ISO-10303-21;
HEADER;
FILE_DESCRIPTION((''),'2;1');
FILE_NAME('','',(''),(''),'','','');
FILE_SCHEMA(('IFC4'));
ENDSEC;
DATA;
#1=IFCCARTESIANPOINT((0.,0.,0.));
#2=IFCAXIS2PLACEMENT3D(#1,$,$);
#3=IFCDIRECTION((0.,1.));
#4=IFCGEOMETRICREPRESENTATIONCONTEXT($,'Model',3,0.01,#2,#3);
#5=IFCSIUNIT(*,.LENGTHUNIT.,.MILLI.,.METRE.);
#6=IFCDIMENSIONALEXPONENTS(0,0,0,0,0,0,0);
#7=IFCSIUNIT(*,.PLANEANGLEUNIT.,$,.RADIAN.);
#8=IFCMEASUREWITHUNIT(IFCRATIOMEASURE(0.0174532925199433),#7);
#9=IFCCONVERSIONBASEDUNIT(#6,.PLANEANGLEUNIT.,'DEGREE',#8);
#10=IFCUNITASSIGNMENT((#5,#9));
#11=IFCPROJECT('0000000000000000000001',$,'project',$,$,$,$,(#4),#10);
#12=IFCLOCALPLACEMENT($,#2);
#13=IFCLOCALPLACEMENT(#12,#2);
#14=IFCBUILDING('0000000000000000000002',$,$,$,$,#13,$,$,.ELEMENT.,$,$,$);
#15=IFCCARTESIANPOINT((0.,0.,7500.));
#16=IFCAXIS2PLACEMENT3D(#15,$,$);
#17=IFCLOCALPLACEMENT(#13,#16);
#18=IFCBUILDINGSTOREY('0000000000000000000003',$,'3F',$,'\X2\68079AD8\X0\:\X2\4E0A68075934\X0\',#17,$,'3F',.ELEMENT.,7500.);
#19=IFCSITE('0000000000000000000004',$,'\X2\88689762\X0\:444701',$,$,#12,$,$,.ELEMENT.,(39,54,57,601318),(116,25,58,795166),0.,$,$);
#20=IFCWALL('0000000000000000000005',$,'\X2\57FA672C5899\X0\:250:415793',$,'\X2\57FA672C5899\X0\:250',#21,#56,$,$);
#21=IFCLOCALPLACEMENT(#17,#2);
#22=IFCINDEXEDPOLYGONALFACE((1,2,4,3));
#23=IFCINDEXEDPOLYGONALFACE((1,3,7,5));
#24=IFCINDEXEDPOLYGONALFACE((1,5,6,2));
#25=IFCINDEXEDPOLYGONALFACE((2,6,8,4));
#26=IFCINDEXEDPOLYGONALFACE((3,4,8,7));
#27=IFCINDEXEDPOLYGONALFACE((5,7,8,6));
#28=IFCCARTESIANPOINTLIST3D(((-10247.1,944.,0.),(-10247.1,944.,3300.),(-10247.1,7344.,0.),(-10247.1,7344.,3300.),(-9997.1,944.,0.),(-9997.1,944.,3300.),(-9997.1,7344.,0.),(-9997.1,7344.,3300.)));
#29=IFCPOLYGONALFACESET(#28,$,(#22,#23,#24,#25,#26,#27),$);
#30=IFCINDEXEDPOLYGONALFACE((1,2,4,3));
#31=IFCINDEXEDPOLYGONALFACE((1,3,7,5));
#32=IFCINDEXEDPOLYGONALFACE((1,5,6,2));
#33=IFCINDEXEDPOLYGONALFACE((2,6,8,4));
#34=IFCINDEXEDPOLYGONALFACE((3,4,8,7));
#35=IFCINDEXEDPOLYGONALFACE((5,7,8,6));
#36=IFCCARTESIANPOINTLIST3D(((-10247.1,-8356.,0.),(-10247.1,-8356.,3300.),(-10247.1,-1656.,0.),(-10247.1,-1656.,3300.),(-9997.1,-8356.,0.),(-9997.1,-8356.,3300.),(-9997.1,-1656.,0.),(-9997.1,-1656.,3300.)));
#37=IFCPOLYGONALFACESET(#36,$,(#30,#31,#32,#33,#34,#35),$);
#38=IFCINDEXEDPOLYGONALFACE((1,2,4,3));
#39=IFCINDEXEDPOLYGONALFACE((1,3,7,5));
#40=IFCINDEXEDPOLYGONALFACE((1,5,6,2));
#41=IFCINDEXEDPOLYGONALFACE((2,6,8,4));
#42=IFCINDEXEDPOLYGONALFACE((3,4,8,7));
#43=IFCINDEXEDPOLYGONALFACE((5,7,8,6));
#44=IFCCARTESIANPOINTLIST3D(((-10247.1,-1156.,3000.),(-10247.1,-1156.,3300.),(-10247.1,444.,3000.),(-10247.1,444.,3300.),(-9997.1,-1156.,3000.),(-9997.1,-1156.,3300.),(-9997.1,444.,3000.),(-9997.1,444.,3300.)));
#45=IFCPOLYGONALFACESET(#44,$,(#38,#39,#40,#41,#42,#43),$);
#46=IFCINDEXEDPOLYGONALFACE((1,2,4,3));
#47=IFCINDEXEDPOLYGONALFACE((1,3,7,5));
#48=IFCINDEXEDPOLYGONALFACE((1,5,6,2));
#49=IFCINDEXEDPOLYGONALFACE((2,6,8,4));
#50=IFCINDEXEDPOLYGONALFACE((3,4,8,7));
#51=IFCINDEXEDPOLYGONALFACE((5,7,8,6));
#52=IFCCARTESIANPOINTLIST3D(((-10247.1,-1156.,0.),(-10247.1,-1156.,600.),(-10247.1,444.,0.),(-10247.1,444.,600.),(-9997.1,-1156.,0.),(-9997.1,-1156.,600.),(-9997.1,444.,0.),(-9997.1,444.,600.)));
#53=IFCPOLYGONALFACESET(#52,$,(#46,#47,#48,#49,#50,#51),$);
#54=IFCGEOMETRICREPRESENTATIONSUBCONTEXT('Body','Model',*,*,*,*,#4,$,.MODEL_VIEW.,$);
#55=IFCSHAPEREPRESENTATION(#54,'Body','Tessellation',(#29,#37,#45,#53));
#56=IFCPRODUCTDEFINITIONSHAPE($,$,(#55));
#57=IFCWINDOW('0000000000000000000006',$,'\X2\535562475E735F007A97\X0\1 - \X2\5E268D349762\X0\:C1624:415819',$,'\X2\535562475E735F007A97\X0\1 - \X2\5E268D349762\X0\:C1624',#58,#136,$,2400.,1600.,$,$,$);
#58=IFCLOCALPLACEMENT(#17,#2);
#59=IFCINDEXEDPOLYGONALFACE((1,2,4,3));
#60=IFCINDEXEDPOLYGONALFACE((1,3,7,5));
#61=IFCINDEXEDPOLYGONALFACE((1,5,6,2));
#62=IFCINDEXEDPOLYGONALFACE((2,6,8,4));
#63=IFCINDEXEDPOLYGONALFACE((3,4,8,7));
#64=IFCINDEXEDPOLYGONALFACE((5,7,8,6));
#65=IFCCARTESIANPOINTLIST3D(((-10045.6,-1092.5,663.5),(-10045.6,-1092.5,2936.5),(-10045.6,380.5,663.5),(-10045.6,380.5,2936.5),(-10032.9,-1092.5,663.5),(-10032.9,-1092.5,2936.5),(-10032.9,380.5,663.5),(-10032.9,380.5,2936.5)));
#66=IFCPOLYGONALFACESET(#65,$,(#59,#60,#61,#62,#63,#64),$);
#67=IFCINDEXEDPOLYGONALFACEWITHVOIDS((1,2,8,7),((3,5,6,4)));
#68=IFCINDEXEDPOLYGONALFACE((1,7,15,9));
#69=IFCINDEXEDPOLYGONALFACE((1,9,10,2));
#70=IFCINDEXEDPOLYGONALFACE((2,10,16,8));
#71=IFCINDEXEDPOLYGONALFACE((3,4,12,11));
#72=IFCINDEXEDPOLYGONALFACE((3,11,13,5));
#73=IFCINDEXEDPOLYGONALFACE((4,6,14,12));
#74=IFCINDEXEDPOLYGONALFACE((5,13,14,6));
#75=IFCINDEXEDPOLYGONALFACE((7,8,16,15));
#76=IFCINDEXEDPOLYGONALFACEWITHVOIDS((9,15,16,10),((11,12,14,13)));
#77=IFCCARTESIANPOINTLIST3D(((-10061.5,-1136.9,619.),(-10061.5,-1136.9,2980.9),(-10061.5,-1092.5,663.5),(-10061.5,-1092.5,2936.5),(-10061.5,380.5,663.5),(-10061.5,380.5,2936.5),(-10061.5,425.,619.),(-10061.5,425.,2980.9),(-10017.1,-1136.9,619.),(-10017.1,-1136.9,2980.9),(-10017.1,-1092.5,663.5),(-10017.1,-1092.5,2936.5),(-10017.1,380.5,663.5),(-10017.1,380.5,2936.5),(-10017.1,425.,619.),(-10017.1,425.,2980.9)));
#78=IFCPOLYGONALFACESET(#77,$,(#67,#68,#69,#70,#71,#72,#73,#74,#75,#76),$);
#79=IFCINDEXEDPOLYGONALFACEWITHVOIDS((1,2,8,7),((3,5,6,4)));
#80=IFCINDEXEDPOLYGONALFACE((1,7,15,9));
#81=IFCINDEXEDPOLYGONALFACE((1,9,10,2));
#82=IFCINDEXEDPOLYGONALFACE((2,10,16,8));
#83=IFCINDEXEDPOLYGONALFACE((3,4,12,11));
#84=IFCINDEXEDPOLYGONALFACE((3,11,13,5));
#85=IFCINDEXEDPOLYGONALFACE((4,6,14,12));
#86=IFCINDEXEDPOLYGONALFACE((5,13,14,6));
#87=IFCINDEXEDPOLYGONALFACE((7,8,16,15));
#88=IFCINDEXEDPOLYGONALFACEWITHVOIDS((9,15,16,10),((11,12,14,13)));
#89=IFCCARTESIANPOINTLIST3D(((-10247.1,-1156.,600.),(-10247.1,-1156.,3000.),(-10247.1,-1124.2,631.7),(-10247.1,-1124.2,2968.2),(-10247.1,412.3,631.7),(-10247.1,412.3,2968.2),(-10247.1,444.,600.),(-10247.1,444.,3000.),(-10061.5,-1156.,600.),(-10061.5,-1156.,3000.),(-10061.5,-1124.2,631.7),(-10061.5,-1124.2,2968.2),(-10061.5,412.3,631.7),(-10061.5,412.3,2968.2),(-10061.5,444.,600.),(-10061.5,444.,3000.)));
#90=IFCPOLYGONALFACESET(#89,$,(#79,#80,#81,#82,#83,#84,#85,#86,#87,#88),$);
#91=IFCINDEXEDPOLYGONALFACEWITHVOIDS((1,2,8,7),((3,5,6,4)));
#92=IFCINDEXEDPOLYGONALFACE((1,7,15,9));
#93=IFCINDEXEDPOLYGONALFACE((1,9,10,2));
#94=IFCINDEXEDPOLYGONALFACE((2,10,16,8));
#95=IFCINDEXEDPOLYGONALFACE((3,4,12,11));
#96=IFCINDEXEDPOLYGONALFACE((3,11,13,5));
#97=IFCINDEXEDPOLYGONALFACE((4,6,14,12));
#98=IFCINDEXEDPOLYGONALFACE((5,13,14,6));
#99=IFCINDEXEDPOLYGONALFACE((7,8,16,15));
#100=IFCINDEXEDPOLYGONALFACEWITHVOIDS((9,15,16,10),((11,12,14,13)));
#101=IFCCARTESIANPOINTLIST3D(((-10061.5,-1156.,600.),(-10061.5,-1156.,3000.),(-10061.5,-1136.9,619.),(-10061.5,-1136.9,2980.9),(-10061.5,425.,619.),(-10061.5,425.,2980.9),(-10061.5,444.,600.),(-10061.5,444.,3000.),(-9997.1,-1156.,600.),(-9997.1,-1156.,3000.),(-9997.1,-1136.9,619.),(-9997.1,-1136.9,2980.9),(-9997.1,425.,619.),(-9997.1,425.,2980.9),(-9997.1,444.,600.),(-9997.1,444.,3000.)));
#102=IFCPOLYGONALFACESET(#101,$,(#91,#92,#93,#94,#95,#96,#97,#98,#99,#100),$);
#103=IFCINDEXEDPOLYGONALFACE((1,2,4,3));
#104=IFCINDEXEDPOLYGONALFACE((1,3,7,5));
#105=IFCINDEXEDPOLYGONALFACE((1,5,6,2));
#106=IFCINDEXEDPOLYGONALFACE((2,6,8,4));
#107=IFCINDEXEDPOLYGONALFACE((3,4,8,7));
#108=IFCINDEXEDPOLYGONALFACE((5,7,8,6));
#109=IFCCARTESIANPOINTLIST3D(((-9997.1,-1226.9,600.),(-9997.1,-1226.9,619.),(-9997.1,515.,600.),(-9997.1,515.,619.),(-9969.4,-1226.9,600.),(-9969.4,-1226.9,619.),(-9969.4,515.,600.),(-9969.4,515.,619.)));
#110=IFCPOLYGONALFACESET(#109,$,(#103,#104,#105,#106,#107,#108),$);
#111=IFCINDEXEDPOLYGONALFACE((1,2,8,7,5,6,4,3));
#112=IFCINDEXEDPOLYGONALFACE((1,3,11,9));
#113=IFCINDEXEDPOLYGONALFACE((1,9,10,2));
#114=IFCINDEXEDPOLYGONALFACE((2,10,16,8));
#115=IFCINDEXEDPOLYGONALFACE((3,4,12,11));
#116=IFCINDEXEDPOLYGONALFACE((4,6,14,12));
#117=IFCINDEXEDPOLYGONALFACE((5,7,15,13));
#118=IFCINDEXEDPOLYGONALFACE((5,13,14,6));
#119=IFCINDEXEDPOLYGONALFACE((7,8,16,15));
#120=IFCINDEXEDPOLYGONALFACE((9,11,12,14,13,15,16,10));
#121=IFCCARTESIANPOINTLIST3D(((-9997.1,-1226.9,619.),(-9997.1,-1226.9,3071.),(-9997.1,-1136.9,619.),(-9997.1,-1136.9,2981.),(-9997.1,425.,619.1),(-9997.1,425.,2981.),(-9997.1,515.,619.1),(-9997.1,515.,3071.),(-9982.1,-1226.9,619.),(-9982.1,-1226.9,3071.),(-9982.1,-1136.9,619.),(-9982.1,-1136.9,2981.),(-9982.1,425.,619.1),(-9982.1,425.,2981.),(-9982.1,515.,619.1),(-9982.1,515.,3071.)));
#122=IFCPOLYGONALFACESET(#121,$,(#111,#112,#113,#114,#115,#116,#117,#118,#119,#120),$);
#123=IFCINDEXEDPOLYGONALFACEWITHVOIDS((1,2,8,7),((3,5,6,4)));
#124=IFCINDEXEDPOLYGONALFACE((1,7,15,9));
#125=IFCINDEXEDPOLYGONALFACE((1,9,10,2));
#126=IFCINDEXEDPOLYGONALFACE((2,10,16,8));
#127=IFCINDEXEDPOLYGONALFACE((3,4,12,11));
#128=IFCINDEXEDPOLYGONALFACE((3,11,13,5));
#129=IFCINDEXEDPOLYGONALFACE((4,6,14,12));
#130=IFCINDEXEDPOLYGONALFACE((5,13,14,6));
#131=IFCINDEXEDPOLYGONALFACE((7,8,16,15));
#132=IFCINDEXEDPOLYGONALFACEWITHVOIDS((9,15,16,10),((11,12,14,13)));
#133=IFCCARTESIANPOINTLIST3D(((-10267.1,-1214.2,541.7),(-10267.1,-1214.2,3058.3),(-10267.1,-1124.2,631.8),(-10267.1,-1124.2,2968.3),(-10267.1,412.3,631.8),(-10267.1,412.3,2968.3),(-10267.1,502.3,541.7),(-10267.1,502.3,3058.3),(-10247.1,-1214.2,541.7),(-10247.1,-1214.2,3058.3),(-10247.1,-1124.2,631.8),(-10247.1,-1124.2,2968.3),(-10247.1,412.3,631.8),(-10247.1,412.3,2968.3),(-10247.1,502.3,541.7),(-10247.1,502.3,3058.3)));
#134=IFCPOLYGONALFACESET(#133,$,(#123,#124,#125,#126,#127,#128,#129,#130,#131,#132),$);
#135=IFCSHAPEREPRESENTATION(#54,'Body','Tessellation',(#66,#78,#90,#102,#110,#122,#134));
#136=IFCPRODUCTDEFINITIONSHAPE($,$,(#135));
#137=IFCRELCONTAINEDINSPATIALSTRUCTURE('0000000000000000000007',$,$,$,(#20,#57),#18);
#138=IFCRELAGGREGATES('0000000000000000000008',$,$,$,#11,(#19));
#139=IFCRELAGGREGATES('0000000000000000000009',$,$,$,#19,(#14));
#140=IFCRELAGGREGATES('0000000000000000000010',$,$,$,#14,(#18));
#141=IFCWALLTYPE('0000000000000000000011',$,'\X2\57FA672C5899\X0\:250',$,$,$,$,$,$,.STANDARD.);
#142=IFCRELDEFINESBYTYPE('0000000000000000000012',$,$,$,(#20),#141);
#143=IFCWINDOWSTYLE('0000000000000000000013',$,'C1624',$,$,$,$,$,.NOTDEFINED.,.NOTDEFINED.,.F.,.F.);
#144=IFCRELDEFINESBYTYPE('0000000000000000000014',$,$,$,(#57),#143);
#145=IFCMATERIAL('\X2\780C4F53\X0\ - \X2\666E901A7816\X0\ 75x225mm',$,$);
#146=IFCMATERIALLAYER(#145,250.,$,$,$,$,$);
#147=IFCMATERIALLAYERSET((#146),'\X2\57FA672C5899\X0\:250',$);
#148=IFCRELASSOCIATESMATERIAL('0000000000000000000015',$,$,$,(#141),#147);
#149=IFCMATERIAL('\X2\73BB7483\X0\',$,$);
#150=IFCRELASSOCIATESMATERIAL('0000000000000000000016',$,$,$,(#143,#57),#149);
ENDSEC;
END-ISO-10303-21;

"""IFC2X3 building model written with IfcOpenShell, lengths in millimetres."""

from ifc_helpers import new_model, entity, si_unit, converted_unit, direction, frame, frame_2d, origin, origin_2d_with_axis, place, context, subcontext, project, spatial, polyline, rectangle, outline, extrude, source, transform, mapped, material, layer, layer_set, type_object, type_shapes, element, fill, save


model = new_model("IFC2X3")

# Units and contexts
model_context = context("Model", 3, precision=0.01, world=origin(), true_north=direction((0.0, 1.0)))
body_context = subcontext(model_context, "Body", "Model", "MODEL_VIEW")
ifc_project = project(units=[si_unit("LENGTHUNIT", "METRE", prefix="MILLI"), converted_unit("PLANEANGLEUNIT", "DEGREE", entity("IfcRatioMeasure", 0.0174532925199433), si_unit("PLANEANGLEUNIT", "RADIAN"), dimensions=[0, 0, 0, 0, 0, 0, 0])], contexts=[model_context])

# Site, building, storey
site_placement = place(None, origin())
site = spatial("IfcSite", under=ifc_project, at=site_placement, Name="表面:444701", CompositionType="ELEMENT", RefLatitude=(39, 54, 57, 601318), RefLongitude=(116, 25, 58, 795166), RefElevation=0.0)
building_placement = place(site_placement, origin())
building = spatial("IfcBuilding", under=site, at=building_placement, CompositionType="ELEMENT")
storey_placement = place(building_placement, frame((0.0, 0.0, 7500.0)))
storey = spatial("IfcBuildingStorey", under=building, at=storey_placement, Name="3F", ObjectType="标高:上标头", LongName="3F", CompositionType="ELEMENT", Elevation=7500.0)

# Wall, opening, window
ifc_material_1 = material(Name="砌体 - 普通砖 75x225mm")
ifc_layer_1 = layer(ifc_material_1, 250.0)
ifc_layer_set_1 = layer_set([ifc_layer_1], Name="基本墙:250")
wall_type_1 = type_object("IfcWallType", Name="基本墙:250", PredefinedType="STANDARD", material=ifc_layer_set_1)
wall_1_placement = place(storey_placement, frame((-10122.1, 7344.0, 0.0), z_axis=(0.0, 0.0, 1.0), x_axis=(0.0, -1.0, 0.0)))
wall_1 = element("IfcWall", 1, at=wall_1_placement, inside=storey, type_object=wall_type_1, Name="基本墙:250:415793", ObjectType="基本墙:250", context=body_context, shape_type="SweptSolid", body=[
    extrude(rectangle(XDim=6400.0, YDim=250.0, at=frame_2d((0.0, 0.0), x_axis=(1.0, 0.0))), frame((3200.0, 0.0, 0.0)), (0.0, 0.0, 1.0), 3300.0),
    extrude(rectangle(XDim=6700.0, YDim=250.0, at=frame_2d((0.0, 0.0), x_axis=(1.0, 0.0))), frame((12350.0, 0.0, 0.0)), (0.0, 0.0, 1.0), 3300.0),
    extrude(rectangle(XDim=250.0, YDim=1600.0, at=frame_2d((0.0, 0.0), x_axis=(1.0, 0.0))), frame((7700.0, 0.0, 3000.0), z_axis=(0.0, 0.0, 1.0), x_axis=(0.0, 1.0, 0.0)), (0.0, 0.0, 1.0), 300.0),
    extrude(rectangle(XDim=1600.0, YDim=250.0, at=frame_2d((0.0, 0.0), x_axis=(1.0, 0.0))), frame((7700.0, 0.0, 0.0)), (0.0, 0.0, 1.0), 600.0),
])
opening_1_placement = place(wall_1_placement, frame((6900.0, -125.0, 600.0)))
opening_1 = element("IfcOpeningElement", 2, at=opening_1_placement, cuts=wall_1, ObjectType="Opening", context=body_context, shape_type="SweptSolid", body=[
    extrude(rectangle(XDim=2400.0, YDim=1600.0, at=frame_2d((1200.0, 800.0), x_axis=(-1.0, 0.0))), frame((0.0, 0.0, 0.0), z_axis=(0.0, 1.0, 0.0), x_axis=(0.0, 0.0, 1.0)), (0.0, 0.0, 1.0), 250.0),
])
ifc_material_2 = material(Name="玻璃")
window_style_1 = type_object("IfcWindowStyle", Name="C1624", ConstructionType="NOTDEFINED", OperationType="NOTDEFINED", ParameterTakesPrecedence=False, Sizeable=False, material=ifc_material_2)
shared_shape_1 = source(origin(), body_context, "Body", "SweptSolid", [
    extrude(rectangle(XDim=12.7, YDim=1473.0, at=origin_2d_with_axis()), frame((800.0, 207.8, 63.5), z_axis=(0.0, 0.0, 1.0), x_axis=(0.0, 1.0, 0.0)), (0.0, 0.0, 1.0), 2273.0),
    extrude(outline(polyline([(-780.9, -1181.0), (780.9, -1181.0), (780.9, 1181.0), (-780.9, 1181.0), (-780.9, -1181.0)]), holes=[polyline([(-736.5, -1136.5), (-736.5, 1136.5), (736.5, 1136.5), (736.5, -1136.5), (-736.5, -1136.5)])]), frame((800.0, 185.6, 1200.0), z_axis=(0.0, 1.0, 0.0), x_axis=(1.0, 0.0, 0.0)), (0.0, 0.0, 1.0), 44.5),
    extrude(outline(polyline([(-800.0, -1200.0), (800.0, -1200.0), (800.0, 1200.0), (-800.0, 1200.0), (-800.0, -1200.0)]), holes=[polyline([(-768.2, -1168.2), (-768.2, 1168.2), (768.2, 1168.2), (768.2, -1168.2), (-768.2, -1168.2)])]), frame((800.0, 0.0, 1200.0), z_axis=(0.0, 1.0, 0.0), x_axis=(1.0, 0.0, 0.0)), (0.0, 0.0, 1.0), 185.6),
    extrude(outline(polyline([(-1200.0, -800.0), (1200.0, -800.0), (1200.0, 800.0), (-1200.0, 800.0), (-1200.0, -800.0)]), holes=[polyline([(-1181.0, -780.9), (-1181.0, 781.0), (1181.0, 781.0), (1181.0, -780.9), (-1181.0, -780.9)])]), frame((800.0, 185.6, 1200.0), z_axis=(0.0, 1.0, 0.0), x_axis=(0.0, 0.0, -1.0)), (0.0, 0.0, 1.0), 64.5),
    extrude(rectangle(XDim=27.7, YDim=1741.9, at=frame_2d((0.0, 0.0), x_axis=(1.0, 0.0))), frame((800.0, 263.9, 0.0), z_axis=(0.0, 0.0, 1.0), x_axis=(0.0, -1.0, 0.0)), (0.0, 0.0, 1.0), 19.0),
    extrude(outline(polyline([(-1158.5, 780.9), (1203.5, 780.9), (1203.5, 870.9), (-1248.5, 870.9), (-1248.5, -870.9), (1203.5, -870.9), (1203.5, -780.9), (-1158.5, -780.9), (-1158.5, 780.9)])), frame((800.0, 250.0, 1222.5), z_axis=(0.0, 1.0, 0.0), x_axis=(0.0, 0.0, -1.0)), (0.0, 0.0, 1.0), 15.0),
    extrude(outline(polyline([(-1258.3, -858.2), (1258.3, -858.2), (1258.3, 858.2), (-1258.3, 858.2), (-1258.3, -858.2)]), holes=[polyline([(-1168.3, -768.2), (-1168.3, 768.3), (1168.2, 768.3), (1168.2, -768.2), (-1168.3, -768.2)])]), frame((800.0, -20.0, 1200.0), z_axis=(0.0, 1.0, 0.0), x_axis=(0.0, 0.0, -1.0)), (0.0, 0.0, 1.0), 20.0),
])
type_shapes(window_style_1, [shared_shape_1])
window_1_placement = place(opening_1_placement, origin())
window_1 = element("IfcWindow", 3, at=window_1_placement, inside=storey, type_object=window_style_1, material=ifc_material_2, Name="单扇平开窗1 - 带贴面:C1624:415819", ObjectType="单扇平开窗1 - 带贴面:C1624", OverallHeight=2400.0, OverallWidth=1600.0, context=body_context, shape_type="MappedRepresentation", body=[
    mapped(shared_shape_1, transform((0.0, 0.0, 0.0), scale=1.0)),
])
fill(opening_1, window_1)

save(model, "model.ifc")
